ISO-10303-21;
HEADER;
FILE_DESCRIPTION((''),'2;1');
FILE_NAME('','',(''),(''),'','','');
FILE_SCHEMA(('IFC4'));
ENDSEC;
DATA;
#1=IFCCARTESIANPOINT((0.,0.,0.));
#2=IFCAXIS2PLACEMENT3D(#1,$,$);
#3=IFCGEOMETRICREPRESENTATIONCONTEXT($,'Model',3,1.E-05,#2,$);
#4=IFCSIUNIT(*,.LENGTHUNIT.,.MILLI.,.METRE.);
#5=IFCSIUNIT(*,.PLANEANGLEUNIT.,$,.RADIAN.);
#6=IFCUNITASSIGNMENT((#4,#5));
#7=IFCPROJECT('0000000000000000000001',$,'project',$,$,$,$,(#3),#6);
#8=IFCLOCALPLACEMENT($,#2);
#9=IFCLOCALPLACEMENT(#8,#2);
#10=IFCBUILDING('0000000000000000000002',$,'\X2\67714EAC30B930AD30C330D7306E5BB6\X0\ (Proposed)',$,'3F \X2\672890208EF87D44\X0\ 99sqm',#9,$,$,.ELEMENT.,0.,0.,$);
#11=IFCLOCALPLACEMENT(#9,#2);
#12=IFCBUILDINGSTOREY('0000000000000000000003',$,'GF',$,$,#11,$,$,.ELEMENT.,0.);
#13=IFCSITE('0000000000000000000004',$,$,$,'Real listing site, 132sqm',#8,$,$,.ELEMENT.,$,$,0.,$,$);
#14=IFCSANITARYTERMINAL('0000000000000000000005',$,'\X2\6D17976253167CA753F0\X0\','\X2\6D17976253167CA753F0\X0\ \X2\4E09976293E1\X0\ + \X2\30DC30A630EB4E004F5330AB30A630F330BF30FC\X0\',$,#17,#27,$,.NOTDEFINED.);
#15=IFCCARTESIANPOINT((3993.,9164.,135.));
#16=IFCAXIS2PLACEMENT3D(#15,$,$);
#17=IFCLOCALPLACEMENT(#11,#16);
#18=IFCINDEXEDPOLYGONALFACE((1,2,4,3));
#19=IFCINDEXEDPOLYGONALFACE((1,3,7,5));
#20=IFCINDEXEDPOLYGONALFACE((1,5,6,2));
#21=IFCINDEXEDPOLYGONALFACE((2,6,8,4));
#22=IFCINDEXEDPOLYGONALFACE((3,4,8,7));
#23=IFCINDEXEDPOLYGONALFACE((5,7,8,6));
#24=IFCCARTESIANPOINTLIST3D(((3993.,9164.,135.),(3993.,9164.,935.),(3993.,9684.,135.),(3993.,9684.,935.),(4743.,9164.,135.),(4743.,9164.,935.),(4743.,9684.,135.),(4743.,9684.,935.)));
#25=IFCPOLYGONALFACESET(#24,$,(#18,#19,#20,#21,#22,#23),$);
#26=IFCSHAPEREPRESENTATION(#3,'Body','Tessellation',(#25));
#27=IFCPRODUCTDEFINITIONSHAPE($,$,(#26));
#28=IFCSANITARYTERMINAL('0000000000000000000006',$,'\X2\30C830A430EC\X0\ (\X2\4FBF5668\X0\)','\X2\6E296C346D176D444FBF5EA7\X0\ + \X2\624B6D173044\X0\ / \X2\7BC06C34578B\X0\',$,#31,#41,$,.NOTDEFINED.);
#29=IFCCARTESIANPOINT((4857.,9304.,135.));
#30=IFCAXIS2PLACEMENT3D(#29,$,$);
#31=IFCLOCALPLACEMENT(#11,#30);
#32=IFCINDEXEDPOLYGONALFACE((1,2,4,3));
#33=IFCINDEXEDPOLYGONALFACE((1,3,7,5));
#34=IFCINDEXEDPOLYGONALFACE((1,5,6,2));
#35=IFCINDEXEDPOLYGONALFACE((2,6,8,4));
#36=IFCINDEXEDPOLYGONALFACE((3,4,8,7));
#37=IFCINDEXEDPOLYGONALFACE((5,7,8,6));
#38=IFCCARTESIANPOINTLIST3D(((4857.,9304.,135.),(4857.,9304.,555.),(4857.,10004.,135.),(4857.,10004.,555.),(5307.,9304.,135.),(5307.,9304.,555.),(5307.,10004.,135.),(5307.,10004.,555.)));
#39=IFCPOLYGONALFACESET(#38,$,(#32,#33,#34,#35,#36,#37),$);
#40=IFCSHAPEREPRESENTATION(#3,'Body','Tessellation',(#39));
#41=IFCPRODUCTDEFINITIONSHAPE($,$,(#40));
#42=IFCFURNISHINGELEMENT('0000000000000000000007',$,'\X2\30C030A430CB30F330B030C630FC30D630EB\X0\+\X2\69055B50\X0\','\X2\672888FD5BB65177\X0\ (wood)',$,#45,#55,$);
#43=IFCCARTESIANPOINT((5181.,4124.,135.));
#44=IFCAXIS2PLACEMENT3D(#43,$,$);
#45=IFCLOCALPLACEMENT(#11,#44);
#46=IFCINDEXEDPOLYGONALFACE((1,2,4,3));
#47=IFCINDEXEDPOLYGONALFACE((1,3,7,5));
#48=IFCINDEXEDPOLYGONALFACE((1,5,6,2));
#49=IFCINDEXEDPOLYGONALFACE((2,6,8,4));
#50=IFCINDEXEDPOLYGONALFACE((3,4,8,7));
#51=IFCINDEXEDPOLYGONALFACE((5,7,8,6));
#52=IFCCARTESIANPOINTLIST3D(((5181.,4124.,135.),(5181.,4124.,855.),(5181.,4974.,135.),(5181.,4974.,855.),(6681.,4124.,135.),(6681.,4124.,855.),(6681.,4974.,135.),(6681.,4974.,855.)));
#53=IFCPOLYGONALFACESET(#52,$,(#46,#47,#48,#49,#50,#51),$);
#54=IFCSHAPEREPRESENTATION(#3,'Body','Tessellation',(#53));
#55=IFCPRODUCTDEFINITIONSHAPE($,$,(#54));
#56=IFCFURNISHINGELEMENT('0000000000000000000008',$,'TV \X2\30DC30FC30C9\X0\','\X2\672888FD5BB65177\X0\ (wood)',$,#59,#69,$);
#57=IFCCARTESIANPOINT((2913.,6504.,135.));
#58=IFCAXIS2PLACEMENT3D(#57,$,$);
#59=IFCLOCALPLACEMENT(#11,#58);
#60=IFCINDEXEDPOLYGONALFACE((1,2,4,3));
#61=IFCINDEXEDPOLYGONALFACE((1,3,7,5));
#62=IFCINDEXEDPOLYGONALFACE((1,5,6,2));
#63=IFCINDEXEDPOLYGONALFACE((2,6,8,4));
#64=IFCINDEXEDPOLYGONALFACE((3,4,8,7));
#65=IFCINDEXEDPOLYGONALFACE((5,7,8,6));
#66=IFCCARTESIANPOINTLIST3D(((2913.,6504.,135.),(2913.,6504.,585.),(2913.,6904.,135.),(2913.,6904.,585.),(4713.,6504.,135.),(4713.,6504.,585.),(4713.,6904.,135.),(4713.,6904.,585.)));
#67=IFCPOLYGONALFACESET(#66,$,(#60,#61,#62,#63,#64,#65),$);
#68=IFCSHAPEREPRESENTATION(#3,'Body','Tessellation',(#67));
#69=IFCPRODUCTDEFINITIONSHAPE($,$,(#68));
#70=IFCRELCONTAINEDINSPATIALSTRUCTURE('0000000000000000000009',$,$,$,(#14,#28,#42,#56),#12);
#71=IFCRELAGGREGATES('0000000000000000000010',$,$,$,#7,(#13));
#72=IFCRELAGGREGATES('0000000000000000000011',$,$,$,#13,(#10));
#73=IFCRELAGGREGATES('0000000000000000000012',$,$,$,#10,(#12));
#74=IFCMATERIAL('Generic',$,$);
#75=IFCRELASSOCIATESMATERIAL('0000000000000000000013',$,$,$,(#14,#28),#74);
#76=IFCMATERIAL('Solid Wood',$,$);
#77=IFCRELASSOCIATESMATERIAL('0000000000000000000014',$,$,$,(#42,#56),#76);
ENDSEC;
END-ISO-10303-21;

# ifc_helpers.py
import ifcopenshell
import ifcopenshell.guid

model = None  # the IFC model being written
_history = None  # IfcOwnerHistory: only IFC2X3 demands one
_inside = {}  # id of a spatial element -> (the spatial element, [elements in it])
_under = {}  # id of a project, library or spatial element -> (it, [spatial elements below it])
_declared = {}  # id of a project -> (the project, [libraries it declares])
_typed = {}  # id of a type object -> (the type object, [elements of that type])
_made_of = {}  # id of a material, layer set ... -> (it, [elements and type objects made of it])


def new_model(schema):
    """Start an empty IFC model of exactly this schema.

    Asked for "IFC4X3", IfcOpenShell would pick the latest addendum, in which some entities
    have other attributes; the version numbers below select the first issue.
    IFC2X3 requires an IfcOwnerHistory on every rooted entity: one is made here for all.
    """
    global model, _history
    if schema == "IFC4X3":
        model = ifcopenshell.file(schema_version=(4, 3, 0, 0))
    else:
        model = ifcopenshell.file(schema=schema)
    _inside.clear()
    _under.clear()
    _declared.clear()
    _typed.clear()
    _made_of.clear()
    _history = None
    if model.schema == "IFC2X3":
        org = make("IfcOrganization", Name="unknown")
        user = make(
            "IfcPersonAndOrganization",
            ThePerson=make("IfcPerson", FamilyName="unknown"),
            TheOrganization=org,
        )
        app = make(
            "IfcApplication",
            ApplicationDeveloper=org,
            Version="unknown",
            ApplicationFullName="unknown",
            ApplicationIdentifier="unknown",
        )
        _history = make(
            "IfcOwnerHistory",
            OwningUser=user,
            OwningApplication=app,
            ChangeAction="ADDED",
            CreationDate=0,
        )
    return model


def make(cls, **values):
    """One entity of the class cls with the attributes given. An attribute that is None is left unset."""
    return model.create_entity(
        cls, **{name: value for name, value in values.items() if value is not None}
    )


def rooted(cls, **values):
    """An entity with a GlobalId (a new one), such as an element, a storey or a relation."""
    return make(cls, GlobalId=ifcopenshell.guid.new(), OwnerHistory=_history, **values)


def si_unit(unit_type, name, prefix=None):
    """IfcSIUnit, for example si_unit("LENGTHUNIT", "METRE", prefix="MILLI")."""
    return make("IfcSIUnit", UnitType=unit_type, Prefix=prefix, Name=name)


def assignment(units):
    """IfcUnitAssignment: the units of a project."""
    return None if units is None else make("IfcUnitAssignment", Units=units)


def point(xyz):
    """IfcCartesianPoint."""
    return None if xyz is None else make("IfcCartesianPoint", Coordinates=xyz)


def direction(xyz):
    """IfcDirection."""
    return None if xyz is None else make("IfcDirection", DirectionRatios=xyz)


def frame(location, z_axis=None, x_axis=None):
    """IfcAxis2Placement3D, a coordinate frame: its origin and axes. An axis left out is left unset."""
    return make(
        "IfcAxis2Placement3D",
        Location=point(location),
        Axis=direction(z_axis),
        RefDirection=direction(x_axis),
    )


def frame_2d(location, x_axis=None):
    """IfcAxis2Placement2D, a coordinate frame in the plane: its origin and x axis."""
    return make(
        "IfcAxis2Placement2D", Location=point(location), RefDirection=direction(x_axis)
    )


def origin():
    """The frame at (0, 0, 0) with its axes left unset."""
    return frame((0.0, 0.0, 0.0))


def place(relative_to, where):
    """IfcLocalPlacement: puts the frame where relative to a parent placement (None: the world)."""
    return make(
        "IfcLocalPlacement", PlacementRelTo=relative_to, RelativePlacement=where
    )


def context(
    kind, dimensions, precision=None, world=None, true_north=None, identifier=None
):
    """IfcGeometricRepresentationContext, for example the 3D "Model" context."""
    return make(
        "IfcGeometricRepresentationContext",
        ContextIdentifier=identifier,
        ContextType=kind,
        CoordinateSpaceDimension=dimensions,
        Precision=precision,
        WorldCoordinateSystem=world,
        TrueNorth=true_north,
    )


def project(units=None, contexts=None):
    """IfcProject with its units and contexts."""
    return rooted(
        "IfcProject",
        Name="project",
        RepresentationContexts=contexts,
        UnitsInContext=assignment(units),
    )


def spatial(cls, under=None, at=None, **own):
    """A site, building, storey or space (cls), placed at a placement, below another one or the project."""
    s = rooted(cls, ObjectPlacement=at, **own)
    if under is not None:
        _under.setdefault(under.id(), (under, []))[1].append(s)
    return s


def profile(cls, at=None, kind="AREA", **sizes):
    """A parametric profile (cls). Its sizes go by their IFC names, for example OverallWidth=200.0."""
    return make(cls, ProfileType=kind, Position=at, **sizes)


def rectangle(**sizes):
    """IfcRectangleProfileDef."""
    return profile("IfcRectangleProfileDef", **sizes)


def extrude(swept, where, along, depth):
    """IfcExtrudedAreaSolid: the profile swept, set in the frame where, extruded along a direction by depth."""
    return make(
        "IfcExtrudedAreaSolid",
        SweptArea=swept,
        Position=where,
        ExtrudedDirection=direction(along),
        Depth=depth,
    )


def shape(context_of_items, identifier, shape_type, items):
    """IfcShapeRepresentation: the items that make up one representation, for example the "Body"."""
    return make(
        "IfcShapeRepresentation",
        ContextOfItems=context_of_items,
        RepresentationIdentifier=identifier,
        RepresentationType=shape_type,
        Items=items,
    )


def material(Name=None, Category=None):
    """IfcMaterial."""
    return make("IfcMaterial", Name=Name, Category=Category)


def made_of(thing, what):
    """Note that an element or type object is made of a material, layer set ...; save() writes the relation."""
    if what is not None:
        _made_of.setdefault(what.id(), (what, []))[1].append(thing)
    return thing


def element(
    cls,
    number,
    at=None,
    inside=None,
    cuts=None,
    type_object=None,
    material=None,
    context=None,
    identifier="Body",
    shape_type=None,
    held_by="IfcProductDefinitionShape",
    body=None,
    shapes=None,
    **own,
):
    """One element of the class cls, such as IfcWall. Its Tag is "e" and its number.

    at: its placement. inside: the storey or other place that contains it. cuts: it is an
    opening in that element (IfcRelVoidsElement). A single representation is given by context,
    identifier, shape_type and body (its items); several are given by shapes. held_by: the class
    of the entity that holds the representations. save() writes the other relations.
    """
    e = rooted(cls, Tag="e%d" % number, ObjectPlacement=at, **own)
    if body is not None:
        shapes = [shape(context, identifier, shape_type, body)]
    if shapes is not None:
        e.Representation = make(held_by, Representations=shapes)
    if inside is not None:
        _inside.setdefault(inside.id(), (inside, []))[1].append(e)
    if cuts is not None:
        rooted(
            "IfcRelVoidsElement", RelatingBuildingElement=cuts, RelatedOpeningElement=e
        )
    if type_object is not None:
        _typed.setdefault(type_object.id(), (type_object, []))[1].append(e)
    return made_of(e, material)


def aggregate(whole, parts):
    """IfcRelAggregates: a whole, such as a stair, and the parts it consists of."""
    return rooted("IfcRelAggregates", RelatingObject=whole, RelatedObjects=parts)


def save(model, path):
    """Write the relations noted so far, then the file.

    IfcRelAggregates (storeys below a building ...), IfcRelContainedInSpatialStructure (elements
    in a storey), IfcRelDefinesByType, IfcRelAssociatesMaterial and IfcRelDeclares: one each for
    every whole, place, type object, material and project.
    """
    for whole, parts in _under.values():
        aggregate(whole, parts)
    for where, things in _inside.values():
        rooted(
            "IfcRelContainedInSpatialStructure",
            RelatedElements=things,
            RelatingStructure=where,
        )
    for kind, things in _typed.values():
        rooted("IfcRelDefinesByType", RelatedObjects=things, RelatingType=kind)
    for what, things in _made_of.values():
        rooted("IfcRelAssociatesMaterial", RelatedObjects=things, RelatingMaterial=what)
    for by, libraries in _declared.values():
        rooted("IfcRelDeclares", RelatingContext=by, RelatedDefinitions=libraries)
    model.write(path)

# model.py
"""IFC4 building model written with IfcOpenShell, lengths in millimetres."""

from ifc_helpers import new_model, si_unit, frame, frame_2d, origin, place, context, project, spatial, rectangle, extrude, material, element, save


model = new_model("IFC4")

# Units and contexts
model_context = context("Model", 3, precision=1e-05, world=origin())
ifc_project = project(units=[si_unit("LENGTHUNIT", "METRE", prefix="MILLI"), si_unit("PLANEANGLEUNIT", "RADIAN")], contexts=[model_context])

# Site, building, storey
site_placement = place(None, origin())
site = spatial("IfcSite", under=ifc_project, at=site_placement, ObjectType="Real listing site, 132sqm", CompositionType="ELEMENT", RefElevation=0.0)
building_placement = place(site_placement, origin())
building = spatial("IfcBuilding", under=site, at=building_placement, Name="東京スキップの家 (Proposed)", ObjectType="3F 木造軸組 99sqm", CompositionType="ELEMENT", ElevationOfRefHeight=0.0, ElevationOfTerrain=0.0)
storey_placement = place(building_placement, origin())
storey = spatial("IfcBuildingStorey", under=building, at=storey_placement, Name="GF", CompositionType="ELEMENT", Elevation=0.0)

# Shared definitions
ifc_material_1 = material(Name="Solid Wood")

# Shared definitions
ifc_material_2 = material(Name="Generic")

# Sanitary terminals
sanitary_terminal_1_placement = place(storey_placement, frame((3993.0, 9164.0, 135.0)))
element("IfcSanitaryTerminal", 1, at=sanitary_terminal_1_placement, inside=storey, material=ifc_material_2, Name="洗面化粧台", Description="洗面化粧台 三面鏡 + ボウル一体カウンター", PredefinedType="NOTDEFINED", context=model_context, shape_type="SweptSolid", body=[
    extrude(rectangle(XDim=750.0, YDim=520.0, at=frame_2d((375.0, 260.0))), frame((3993.0, 9164.0, 135.0)), (0.0, 0.0, 1.0), 800.0),
])
sanitary_terminal_2_placement = place(storey_placement, frame((4857.0, 9304.0, 135.0)))
element("IfcSanitaryTerminal", 2, at=sanitary_terminal_2_placement, inside=storey, material=ifc_material_2, Name="トイレ (便器)", Description="温水洗浄便座 + 手洗い / 節水型", PredefinedType="NOTDEFINED", context=model_context, shape_type="SweptSolid", body=[
    extrude(rectangle(XDim=450.0, YDim=700.0, at=frame_2d((225.0, 350.0))), frame((4857.0, 9304.0, 135.0)), (0.0, 0.0, 1.0), 420.0),
])

# Furnishing elements
furnishing_1_placement = place(storey_placement, frame((5181.0, 4124.0, 135.0)))
element("IfcFurnishingElement", 3, at=furnishing_1_placement, inside=storey, material=ifc_material_1, Name="ダイニングテーブル+椅子", Description="木製家具 (wood)", context=model_context, shape_type="SweptSolid", body=[
    extrude(rectangle(XDim=1500.0, YDim=850.0, at=frame_2d((750.0, 425.0))), frame((5181.0, 4124.0, 135.0)), (0.0, 0.0, 1.0), 720.0),
])
furnishing_2_placement = place(storey_placement, frame((2913.0, 6504.0, 135.0)))
element("IfcFurnishingElement", 4, at=furnishing_2_placement, inside=storey, material=ifc_material_1, Name="TV ボード", Description="木製家具 (wood)", context=model_context, shape_type="SweptSolid", body=[
    extrude(rectangle(XDim=1800.0, YDim=400.0, at=frame_2d((900.0, 200.0))), frame((2913.0, 6504.0, 135.0)), (0.0, 0.0, 1.0), 450.0),
])

save(model, "model.ifc")
